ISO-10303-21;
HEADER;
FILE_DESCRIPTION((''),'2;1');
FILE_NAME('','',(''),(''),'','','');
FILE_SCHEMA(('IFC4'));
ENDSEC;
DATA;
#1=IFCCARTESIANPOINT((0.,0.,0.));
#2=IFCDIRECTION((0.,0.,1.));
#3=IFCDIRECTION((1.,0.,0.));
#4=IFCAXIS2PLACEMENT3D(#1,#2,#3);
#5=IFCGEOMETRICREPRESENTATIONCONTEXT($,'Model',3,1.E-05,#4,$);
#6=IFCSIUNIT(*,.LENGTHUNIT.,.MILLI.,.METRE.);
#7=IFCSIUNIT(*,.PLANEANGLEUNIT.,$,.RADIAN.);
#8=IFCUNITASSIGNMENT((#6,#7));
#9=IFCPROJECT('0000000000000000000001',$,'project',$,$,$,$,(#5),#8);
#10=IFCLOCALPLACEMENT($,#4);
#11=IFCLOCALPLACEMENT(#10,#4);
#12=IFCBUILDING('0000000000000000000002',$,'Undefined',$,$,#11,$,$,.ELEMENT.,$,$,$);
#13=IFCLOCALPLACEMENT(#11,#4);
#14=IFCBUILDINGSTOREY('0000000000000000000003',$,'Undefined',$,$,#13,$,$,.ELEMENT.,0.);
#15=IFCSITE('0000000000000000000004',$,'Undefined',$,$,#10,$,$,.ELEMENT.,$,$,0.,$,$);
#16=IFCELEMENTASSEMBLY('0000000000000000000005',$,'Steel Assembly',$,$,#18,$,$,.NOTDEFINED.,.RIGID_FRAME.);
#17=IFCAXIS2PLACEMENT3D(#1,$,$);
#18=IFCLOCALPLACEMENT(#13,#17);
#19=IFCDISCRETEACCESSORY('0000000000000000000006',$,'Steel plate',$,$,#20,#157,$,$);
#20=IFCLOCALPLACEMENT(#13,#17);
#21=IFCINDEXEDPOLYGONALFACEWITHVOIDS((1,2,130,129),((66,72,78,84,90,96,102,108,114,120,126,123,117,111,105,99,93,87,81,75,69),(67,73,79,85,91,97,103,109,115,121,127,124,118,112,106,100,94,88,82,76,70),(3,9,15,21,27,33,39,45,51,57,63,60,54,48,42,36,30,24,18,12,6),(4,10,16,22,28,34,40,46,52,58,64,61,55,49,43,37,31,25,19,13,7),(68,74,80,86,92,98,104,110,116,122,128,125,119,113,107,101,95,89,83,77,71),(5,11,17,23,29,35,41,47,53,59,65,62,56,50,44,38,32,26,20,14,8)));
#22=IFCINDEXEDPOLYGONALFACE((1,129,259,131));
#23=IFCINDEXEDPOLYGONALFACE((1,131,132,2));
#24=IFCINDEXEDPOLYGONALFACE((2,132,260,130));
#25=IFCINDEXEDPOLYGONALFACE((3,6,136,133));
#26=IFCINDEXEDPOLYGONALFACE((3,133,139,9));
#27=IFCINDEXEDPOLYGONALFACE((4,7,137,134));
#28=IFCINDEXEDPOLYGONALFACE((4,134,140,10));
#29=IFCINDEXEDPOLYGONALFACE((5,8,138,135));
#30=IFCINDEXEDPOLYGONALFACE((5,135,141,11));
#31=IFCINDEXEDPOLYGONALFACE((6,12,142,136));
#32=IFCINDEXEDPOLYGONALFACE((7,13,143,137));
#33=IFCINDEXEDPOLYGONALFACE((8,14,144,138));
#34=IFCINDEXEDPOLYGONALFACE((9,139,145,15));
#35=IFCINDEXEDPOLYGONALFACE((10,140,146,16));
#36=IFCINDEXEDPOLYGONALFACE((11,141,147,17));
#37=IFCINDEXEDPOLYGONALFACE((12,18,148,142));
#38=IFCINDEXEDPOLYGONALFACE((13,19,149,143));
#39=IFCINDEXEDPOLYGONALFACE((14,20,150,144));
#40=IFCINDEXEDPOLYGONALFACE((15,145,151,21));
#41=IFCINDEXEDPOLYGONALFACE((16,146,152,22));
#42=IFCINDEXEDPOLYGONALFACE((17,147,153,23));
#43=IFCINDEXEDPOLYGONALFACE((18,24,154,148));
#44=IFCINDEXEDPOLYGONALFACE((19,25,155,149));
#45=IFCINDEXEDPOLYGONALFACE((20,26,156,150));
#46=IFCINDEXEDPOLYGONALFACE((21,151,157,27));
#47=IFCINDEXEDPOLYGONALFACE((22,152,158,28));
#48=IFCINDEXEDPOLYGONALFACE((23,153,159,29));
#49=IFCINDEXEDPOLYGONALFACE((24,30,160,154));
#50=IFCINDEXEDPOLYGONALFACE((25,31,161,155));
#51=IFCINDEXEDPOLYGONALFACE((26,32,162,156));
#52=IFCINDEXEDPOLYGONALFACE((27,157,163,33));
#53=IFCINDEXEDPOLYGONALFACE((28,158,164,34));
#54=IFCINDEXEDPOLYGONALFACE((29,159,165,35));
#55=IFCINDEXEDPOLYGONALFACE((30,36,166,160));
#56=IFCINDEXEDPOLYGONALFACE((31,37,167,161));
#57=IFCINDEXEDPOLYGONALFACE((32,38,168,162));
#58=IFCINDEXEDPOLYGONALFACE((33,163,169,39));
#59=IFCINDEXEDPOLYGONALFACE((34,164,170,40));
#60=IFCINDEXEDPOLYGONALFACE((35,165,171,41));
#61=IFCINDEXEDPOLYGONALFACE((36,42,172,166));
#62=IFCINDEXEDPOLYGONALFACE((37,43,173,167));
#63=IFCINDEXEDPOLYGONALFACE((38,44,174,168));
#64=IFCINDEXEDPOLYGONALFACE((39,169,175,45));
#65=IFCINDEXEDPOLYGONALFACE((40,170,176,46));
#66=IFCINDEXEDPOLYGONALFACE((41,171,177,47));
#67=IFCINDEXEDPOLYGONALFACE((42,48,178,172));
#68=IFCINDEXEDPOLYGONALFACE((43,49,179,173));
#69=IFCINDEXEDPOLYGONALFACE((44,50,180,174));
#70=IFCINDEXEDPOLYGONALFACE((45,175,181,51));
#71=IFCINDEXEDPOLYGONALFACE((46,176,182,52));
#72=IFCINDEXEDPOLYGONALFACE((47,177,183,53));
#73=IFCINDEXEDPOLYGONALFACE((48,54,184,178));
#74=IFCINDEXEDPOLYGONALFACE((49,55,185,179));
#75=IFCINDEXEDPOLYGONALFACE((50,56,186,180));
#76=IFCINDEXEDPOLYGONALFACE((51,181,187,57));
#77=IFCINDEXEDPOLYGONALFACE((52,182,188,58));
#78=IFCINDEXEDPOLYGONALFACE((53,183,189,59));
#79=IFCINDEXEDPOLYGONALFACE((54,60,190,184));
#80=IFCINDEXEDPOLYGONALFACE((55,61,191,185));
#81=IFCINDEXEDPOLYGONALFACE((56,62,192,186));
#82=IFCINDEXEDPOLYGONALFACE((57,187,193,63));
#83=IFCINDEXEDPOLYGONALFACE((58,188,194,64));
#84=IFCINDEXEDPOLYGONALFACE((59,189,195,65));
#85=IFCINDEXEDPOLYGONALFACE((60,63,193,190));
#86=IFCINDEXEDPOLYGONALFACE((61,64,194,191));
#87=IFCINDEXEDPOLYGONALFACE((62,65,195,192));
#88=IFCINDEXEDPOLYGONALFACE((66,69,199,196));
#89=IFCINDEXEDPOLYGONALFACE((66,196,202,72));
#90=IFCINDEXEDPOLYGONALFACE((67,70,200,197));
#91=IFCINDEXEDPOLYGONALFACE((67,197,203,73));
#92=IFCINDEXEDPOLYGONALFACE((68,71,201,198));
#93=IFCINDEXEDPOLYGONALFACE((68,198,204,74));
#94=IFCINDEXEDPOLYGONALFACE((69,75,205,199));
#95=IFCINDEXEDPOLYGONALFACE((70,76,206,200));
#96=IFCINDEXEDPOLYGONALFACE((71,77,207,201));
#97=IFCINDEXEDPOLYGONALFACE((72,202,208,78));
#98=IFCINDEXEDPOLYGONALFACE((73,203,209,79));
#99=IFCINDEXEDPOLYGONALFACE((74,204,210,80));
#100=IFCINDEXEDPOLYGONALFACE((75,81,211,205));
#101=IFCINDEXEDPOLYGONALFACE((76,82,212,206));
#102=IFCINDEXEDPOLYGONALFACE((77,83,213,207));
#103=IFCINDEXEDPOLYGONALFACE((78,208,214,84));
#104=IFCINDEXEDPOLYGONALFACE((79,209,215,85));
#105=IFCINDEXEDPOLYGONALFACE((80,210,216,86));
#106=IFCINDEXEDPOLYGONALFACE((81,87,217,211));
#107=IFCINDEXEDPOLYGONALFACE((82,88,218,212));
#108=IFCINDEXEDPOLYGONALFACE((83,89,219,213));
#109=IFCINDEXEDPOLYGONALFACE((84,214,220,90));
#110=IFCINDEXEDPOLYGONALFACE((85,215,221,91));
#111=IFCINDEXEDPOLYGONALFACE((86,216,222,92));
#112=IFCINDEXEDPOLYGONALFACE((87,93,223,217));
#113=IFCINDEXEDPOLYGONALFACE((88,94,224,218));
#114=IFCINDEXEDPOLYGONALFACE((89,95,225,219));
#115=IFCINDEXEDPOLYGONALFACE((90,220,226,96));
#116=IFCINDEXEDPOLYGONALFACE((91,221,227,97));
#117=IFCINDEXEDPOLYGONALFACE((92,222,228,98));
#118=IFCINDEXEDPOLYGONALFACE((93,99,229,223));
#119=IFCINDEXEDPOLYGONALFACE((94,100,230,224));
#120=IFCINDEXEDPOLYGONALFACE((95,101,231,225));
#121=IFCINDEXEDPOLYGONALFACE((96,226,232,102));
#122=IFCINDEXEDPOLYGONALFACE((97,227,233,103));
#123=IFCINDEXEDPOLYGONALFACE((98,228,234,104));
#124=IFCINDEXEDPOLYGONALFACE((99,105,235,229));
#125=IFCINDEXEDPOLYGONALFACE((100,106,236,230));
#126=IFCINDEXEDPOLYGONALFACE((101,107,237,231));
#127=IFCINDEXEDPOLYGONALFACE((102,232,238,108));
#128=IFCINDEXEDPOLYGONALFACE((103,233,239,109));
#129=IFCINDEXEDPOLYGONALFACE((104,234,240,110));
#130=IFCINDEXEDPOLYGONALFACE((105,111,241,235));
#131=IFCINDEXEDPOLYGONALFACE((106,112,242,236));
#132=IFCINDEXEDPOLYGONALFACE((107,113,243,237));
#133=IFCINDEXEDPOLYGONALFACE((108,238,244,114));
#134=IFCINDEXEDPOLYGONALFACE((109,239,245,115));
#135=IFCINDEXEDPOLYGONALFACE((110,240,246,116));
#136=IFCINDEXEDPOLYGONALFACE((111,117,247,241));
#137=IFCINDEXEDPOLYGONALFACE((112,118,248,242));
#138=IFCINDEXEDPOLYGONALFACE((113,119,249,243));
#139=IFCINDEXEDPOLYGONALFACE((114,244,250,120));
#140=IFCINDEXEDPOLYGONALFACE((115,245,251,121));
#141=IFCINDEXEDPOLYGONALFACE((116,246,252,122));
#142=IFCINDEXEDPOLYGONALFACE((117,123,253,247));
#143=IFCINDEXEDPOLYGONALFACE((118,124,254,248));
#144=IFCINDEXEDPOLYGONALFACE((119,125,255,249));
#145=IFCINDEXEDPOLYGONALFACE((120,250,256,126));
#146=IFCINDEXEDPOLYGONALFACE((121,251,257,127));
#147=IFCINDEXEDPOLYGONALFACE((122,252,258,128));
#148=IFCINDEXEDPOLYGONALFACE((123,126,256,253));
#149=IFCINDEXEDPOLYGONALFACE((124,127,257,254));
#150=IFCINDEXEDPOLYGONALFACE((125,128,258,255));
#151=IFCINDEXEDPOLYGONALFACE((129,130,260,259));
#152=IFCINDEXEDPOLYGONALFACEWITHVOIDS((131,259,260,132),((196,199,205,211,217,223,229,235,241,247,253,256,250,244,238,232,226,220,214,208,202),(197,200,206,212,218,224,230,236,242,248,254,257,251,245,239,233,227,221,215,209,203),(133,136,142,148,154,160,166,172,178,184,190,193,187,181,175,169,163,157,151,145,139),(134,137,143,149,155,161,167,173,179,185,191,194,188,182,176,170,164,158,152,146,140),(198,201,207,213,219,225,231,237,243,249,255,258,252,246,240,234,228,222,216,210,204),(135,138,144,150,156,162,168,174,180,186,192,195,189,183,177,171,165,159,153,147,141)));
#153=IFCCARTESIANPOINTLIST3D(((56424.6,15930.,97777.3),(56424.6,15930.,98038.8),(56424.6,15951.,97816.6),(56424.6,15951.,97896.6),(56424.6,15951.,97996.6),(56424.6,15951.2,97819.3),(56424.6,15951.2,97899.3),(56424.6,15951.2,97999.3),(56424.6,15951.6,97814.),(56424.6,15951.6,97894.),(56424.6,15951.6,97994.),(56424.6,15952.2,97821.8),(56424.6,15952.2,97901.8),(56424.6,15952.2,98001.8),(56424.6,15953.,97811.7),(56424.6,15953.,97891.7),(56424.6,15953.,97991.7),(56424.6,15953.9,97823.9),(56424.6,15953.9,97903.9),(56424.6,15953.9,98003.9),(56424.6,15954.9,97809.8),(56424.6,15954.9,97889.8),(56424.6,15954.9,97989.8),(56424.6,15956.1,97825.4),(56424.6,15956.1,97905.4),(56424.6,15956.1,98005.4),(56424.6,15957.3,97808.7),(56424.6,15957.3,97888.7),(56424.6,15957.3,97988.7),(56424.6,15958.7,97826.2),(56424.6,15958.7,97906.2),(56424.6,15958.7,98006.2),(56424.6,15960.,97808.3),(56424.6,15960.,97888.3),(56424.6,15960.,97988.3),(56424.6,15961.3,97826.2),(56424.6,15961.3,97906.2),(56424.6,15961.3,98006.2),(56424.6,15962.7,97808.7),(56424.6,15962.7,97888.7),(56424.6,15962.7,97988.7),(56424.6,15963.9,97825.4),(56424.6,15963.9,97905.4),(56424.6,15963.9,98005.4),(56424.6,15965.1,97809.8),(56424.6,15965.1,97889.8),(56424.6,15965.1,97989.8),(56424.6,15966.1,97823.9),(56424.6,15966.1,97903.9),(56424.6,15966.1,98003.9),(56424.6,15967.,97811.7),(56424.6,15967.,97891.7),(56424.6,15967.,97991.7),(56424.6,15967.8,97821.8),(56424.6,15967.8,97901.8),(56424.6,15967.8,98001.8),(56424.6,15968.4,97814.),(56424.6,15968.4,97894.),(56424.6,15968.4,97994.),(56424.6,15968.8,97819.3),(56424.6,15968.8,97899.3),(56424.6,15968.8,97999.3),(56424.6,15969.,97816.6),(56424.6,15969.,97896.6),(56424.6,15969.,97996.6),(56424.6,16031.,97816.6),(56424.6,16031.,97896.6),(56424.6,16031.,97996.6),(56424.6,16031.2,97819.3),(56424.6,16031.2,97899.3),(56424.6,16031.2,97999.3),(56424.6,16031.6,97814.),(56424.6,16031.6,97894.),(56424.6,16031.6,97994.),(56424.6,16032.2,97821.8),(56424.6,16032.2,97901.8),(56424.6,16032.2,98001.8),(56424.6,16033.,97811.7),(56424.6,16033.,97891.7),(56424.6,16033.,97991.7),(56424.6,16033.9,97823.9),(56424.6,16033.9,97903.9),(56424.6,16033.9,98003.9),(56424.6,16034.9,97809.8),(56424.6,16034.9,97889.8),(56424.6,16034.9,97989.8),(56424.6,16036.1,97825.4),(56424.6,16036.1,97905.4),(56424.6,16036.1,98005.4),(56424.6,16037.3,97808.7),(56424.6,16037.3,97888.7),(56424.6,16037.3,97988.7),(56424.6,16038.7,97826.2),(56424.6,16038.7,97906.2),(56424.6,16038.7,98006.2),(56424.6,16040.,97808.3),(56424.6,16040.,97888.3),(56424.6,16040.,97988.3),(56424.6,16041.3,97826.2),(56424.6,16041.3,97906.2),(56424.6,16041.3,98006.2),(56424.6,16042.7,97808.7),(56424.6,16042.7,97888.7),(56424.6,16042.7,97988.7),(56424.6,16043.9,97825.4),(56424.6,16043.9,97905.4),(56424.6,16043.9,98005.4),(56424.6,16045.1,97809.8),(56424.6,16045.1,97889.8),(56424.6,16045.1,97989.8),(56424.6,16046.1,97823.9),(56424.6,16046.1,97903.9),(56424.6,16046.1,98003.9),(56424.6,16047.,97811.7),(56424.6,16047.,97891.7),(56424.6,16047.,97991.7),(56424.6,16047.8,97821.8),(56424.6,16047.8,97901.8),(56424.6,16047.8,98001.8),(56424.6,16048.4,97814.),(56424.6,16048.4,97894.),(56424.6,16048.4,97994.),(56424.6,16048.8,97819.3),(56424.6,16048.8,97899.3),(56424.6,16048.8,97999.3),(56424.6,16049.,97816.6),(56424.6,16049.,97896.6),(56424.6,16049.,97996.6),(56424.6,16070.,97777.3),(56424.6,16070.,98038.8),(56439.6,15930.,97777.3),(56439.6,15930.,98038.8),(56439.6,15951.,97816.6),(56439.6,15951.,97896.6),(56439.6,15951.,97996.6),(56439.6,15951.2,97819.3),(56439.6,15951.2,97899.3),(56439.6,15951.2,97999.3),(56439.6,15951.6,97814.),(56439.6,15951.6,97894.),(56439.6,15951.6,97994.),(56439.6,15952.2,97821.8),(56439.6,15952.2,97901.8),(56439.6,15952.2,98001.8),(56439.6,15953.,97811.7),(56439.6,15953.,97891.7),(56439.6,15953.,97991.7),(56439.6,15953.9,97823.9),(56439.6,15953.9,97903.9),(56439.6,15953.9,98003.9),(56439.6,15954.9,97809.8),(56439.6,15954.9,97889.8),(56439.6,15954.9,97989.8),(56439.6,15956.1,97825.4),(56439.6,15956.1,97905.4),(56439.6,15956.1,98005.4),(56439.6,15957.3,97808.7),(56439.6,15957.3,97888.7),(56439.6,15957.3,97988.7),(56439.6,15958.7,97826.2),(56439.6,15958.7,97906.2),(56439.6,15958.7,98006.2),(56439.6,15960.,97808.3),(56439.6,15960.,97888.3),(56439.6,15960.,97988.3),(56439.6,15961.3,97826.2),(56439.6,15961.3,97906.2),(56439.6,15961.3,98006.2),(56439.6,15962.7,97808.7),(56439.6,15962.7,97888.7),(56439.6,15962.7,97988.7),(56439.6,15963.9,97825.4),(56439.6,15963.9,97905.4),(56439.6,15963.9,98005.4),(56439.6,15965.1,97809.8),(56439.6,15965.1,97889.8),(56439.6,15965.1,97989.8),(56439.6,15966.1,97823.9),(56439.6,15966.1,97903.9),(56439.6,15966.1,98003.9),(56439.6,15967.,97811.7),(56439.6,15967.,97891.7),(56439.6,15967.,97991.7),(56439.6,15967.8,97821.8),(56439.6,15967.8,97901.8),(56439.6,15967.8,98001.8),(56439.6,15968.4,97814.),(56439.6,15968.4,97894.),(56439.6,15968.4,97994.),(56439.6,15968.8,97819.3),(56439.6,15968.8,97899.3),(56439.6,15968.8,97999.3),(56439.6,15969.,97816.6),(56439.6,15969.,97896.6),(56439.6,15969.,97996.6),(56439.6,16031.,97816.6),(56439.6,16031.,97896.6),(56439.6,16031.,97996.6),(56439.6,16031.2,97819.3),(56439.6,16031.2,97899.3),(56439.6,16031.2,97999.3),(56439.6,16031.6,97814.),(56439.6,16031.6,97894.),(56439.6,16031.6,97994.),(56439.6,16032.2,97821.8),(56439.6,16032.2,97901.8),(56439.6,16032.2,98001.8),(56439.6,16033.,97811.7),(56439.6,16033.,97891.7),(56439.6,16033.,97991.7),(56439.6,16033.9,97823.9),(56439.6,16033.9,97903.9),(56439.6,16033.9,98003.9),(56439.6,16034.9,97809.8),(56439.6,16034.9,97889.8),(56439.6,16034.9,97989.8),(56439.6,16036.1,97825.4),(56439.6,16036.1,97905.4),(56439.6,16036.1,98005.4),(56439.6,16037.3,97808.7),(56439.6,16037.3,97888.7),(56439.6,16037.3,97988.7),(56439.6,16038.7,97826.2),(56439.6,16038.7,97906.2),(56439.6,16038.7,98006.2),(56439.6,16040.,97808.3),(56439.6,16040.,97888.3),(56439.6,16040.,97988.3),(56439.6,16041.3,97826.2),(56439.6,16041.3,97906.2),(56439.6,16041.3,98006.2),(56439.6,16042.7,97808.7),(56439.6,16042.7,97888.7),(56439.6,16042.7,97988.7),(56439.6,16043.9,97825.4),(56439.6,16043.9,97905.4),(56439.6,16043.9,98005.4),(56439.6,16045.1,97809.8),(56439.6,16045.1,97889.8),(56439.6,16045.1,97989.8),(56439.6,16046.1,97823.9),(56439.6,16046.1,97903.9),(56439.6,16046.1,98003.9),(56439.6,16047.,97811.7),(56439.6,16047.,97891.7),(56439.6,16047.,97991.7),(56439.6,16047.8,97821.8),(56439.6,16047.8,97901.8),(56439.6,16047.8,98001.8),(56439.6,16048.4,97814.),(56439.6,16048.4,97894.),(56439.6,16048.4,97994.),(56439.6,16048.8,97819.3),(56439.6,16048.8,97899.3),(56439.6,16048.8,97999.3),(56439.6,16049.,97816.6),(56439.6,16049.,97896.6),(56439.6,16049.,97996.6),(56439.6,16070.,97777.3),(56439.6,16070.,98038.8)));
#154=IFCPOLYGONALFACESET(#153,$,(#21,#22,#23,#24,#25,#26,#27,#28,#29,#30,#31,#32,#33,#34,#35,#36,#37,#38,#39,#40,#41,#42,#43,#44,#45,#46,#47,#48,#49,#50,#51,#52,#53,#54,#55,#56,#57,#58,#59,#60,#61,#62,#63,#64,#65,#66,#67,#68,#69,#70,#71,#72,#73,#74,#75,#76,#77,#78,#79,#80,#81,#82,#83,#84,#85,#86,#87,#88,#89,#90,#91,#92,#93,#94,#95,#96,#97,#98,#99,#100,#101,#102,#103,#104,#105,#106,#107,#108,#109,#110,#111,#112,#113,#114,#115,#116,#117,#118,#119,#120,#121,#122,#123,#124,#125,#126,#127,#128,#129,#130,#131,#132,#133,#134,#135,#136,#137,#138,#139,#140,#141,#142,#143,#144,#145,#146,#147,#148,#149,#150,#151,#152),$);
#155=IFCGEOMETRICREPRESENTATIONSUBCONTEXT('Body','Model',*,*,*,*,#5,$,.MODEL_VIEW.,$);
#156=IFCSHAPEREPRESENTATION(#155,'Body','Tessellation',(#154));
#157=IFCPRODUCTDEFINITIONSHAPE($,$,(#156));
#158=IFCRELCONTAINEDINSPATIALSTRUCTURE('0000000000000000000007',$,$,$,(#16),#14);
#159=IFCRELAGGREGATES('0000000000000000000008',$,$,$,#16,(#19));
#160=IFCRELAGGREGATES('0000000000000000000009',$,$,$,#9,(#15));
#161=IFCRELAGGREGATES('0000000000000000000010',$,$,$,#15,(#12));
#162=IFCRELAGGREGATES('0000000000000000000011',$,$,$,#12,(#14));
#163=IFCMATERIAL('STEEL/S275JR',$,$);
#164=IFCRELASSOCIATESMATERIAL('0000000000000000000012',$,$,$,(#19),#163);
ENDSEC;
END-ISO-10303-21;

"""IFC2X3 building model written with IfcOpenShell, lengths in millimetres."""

from ifc_helpers import new_model, si_unit, frame, origin_with_axes, origin_2d_with_axis, place, context, subcontext, project, spatial, polyline, circle, outline, extrude, source, transform, mapped, material, element, aggregate, save


model = new_model("IFC2X3")

# Units and contexts
model_context = context("Model", 3, precision=1e-05, world=origin_with_axes())
body_context = subcontext(model_context, "Body", "Model", "MODEL_VIEW")
ifc_project = project(units=[si_unit("LENGTHUNIT", "METRE", prefix="MILLI"), si_unit("PLANEANGLEUNIT", "RADIAN")], contexts=[model_context])

# Site, building, storey
site_placement = place(None, origin_with_axes())
site = spatial("IfcSite", under=ifc_project, at=site_placement, Name="Undefined", CompositionType="ELEMENT", RefElevation=0.0)
building_placement = place(site_placement, origin_with_axes())
building = spatial("IfcBuilding", under=site, at=building_placement, Name="Undefined", CompositionType="ELEMENT")
storey_placement = place(building_placement, origin_with_axes())
storey = spatial("IfcBuildingStorey", under=building, at=storey_placement, Name="Undefined", CompositionType="ELEMENT", Elevation=0.0)

# Shared definitions
ifc_material_1 = material(Name="STEEL/S275JR")

# Element assembly
assembly_1_placement = place(storey_placement, origin_with_axes())
assembly_1 = element("IfcElementAssembly", 1, at=assembly_1_placement, inside=storey, Name="Steel Assembly", AssemblyPlace="NOTDEFINED", PredefinedType="RIGID_FRAME")

# Discrete accessory, opening
discrete_accessory_1_placement = place(assembly_1_placement, frame((56432.1, 15930.0, 98038.8), z_axis=(-1.0, 0.0, 0.0), x_axis=(0.0, 1.0, 0.0)))
discrete_accessory_1 = element("IfcDiscreteAccessory", 2, at=discrete_accessory_1_placement, material=ifc_material_1, Name="Steel plate", context=body_context, shape_type="SweptSolid", body=[
    extrude(outline(polyline([(0.0, 0.0), (140.0, 0.0), (140.0, 261.5), (0.0, 261.5), (0.0, 0.0)])), frame((0.0, 0.0, -7.5), z_axis=(0.0, 0.0, 1.0), x_axis=(1.0, 0.0, 0.0)), (0.0, 0.0, 1.0), 15.0),
])
shared_shape_1 = source(origin_with_axes(), body_context, "Body", "SweptSolid", [
    extrude(circle(Radius=9.0, at=origin_2d_with_axis()), frame((0.0, -15.1, 0.0), z_axis=(0.0, 1.0, 0.0), x_axis=(1.0, 0.0, 0.0)), (0.0, 0.0, 1.0), 30.3),
])
opening_1_placement = place(assembly_1_placement, frame((56439.6, 16000.0, 97997.3), z_axis=(0.0, -1.0, 0.0), x_axis=(0.0, 0.0, -1.0)))
element("IfcOpeningElement", 3, at=opening_1_placement, cuts=discrete_accessory_1, ObjectType="Opening", context=body_context, shape_type="MappedRepresentation", body=[
    mapped(shared_shape_1, transform((0.0, 0.0, -40.0))),
    mapped(shared_shape_1, transform((100.0, 0.0, -40.0))),
    mapped(shared_shape_1, transform((180.0, 0.0, -40.0))),
    mapped(shared_shape_1, transform((0.0, 0.0, 40.0))),
    mapped(shared_shape_1, transform((100.0, 0.0, 40.0))),
    mapped(shared_shape_1, transform((180.0, 0.0, 40.0))),
])
aggregate(assembly_1, [discrete_accessory_1])

save(model, "model.ifc")
